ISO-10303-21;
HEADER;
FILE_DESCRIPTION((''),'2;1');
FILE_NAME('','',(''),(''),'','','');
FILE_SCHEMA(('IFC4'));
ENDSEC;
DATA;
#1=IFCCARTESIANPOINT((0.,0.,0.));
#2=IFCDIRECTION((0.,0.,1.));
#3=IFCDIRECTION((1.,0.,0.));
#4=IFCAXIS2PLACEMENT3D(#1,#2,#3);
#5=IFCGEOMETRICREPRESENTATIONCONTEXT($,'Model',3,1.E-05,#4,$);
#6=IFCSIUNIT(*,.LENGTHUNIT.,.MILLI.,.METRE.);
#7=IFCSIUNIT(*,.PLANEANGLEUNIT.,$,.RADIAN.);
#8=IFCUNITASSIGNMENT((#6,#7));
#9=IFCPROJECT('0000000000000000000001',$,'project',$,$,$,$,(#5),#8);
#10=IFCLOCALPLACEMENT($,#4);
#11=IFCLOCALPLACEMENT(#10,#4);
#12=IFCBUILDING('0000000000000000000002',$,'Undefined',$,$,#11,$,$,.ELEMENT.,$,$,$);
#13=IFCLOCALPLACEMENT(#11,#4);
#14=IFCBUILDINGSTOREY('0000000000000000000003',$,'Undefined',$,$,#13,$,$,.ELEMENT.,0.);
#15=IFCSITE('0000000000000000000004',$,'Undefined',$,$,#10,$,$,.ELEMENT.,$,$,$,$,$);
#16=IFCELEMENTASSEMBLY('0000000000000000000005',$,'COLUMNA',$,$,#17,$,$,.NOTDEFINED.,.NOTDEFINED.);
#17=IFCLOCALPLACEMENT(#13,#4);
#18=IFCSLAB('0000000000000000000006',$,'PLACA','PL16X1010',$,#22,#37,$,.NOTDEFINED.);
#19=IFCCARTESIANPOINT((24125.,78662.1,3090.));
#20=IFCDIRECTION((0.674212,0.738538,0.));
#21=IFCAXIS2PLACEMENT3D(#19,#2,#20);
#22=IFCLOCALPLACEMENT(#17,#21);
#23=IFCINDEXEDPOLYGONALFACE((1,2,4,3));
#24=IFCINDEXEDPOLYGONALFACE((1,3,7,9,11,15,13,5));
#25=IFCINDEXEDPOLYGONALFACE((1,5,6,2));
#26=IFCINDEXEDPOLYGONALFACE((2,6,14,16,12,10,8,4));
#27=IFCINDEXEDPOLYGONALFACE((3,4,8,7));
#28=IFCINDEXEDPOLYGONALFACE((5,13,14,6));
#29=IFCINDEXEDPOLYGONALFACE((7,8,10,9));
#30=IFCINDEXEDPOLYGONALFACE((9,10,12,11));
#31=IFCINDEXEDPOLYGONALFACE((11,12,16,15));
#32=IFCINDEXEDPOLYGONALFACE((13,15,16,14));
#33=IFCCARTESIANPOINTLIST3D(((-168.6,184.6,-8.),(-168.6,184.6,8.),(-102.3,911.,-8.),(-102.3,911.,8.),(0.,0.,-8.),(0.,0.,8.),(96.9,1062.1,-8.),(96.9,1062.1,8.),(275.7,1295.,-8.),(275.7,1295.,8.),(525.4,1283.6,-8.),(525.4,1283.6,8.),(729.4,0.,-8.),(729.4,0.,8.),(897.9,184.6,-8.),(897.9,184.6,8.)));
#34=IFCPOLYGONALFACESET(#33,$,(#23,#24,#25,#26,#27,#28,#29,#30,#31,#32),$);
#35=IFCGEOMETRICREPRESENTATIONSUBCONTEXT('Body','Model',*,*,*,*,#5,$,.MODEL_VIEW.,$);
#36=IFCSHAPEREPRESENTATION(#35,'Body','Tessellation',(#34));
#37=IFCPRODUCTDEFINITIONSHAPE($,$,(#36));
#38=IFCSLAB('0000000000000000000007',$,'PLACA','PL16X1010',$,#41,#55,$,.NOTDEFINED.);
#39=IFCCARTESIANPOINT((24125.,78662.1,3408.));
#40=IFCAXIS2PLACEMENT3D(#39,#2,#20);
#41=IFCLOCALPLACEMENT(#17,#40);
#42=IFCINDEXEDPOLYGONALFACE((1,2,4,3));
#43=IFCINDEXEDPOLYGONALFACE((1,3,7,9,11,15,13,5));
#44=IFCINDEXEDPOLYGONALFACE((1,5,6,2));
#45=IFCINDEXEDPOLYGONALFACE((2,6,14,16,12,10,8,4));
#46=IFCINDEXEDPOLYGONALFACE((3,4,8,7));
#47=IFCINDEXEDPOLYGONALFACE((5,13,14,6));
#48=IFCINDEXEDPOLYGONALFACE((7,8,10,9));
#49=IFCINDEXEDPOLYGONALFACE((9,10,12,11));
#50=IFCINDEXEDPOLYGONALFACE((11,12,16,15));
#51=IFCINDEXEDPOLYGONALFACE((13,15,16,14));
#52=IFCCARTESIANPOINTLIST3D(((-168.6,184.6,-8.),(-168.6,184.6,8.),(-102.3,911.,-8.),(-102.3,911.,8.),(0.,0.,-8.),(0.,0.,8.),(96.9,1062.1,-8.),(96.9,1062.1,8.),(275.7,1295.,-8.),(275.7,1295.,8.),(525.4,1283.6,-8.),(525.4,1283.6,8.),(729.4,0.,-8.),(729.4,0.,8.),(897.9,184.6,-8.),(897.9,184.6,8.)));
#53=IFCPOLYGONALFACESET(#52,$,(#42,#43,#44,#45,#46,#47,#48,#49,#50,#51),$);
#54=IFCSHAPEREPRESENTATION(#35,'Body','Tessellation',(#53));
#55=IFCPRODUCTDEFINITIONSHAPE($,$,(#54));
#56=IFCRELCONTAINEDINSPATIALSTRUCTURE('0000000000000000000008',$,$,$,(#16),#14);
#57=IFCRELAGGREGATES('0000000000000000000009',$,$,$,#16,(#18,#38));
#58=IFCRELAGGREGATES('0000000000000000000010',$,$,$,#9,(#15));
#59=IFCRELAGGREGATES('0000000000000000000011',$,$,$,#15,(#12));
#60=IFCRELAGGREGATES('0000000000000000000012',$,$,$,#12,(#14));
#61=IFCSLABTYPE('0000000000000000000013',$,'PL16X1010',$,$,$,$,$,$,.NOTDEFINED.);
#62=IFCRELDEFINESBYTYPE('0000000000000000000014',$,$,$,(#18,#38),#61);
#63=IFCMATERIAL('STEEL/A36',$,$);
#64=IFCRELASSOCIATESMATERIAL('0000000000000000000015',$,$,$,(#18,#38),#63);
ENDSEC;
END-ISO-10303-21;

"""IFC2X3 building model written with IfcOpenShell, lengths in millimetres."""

from ifc_helpers import new_model, si_unit, frame, origin_with_axes, place, context, subcontext, project, spatial, polyline, outline, extrude, material, type_object, element, aggregate, save


model = new_model("IFC2X3")

# Units and contexts
model_context = context("Model", 3, precision=1e-05, world=origin_with_axes())
body_context = subcontext(model_context, "Body", "Model", "MODEL_VIEW")
ifc_project = project(units=[si_unit("LENGTHUNIT", "METRE", prefix="MILLI"), si_unit("PLANEANGLEUNIT", "RADIAN")], contexts=[model_context])

# Site, building, storey
site_placement = place(None, origin_with_axes())
site = spatial("IfcSite", under=ifc_project, at=site_placement, Name="Undefined", CompositionType="ELEMENT")
building_placement = place(site_placement, origin_with_axes())
building = spatial("IfcBuilding", under=site, at=building_placement, Name="Undefined", CompositionType="ELEMENT")
storey_placement = place(building_placement, origin_with_axes())
storey = spatial("IfcBuildingStorey", under=building, at=storey_placement, Name="Undefined", CompositionType="ELEMENT", Elevation=0.0)

# Shared definitions
ifc_material_1 = material(Name="STEEL/A36")

# Element assembly
assembly_1_placement = place(storey_placement, origin_with_axes())
assembly_1 = element("IfcElementAssembly", 1, at=assembly_1_placement, inside=storey, Name="COLUMNA", AssemblyPlace="NOTDEFINED", PredefinedType="NOTDEFINED")

# Slabs
slab_type = type_object("IfcSlabType", Name="PL16X1010", PredefinedType="NOTDEFINED")
slab_1_placement = place(assembly_1_placement, frame((24125.0, 78662.1, 3090.0), z_axis=(0.0, 0.0, 1.0), x_axis=(0.674212, 0.738538, 0.0)))
slab_1 = element("IfcSlab", 2, at=slab_1_placement, type_object=slab_type, material=ifc_material_1, Name="PLACA", Description="PL16X1010", PredefinedType="NOTDEFINED", context=body_context, shape_type="SweptSolid", body=[
    extrude(outline(polyline([(0.0, 0.0), (729.4, 0.0), (897.9, 184.6), (525.4, 1283.6), (275.7, 1295.0), (96.9, 1062.1), (-102.3, 911.0), (-168.6, 184.6), (0.0, 0.0)])), frame((0.0, 0.0, -8.0), z_axis=(0.0, 0.0, 1.0), x_axis=(1.0, 0.0, 0.0)), (0.0, 0.0, 1.0), 16.0),
])
slab_2_placement = place(assembly_1_placement, frame((24125.0, 78662.1, 3408.0), z_axis=(0.0, 0.0, 1.0), x_axis=(0.674212, 0.738538, 0.0)))
slab_2 = element("IfcSlab", 3, at=slab_2_placement, type_object=slab_type, material=ifc_material_1, Name="PLACA", Description="PL16X1010", PredefinedType="NOTDEFINED", context=body_context, shape_type="SweptSolid", body=[
    extrude(outline(polyline([(0.0, 0.0), (729.4, 0.0), (897.9, 184.6), (525.4, 1283.6), (275.7, 1295.0), (96.9, 1062.1), (-102.3, 911.0), (-168.6, 184.6), (0.0, 0.0)])), frame((0.0, 0.0, -8.0), z_axis=(0.0, 0.0, 1.0), x_axis=(1.0, 0.0, 0.0)), (0.0, 0.0, 1.0), 16.0),
])

aggregate(assembly_1, [slab_1, slab_2])

save(model, "model.ifc")
